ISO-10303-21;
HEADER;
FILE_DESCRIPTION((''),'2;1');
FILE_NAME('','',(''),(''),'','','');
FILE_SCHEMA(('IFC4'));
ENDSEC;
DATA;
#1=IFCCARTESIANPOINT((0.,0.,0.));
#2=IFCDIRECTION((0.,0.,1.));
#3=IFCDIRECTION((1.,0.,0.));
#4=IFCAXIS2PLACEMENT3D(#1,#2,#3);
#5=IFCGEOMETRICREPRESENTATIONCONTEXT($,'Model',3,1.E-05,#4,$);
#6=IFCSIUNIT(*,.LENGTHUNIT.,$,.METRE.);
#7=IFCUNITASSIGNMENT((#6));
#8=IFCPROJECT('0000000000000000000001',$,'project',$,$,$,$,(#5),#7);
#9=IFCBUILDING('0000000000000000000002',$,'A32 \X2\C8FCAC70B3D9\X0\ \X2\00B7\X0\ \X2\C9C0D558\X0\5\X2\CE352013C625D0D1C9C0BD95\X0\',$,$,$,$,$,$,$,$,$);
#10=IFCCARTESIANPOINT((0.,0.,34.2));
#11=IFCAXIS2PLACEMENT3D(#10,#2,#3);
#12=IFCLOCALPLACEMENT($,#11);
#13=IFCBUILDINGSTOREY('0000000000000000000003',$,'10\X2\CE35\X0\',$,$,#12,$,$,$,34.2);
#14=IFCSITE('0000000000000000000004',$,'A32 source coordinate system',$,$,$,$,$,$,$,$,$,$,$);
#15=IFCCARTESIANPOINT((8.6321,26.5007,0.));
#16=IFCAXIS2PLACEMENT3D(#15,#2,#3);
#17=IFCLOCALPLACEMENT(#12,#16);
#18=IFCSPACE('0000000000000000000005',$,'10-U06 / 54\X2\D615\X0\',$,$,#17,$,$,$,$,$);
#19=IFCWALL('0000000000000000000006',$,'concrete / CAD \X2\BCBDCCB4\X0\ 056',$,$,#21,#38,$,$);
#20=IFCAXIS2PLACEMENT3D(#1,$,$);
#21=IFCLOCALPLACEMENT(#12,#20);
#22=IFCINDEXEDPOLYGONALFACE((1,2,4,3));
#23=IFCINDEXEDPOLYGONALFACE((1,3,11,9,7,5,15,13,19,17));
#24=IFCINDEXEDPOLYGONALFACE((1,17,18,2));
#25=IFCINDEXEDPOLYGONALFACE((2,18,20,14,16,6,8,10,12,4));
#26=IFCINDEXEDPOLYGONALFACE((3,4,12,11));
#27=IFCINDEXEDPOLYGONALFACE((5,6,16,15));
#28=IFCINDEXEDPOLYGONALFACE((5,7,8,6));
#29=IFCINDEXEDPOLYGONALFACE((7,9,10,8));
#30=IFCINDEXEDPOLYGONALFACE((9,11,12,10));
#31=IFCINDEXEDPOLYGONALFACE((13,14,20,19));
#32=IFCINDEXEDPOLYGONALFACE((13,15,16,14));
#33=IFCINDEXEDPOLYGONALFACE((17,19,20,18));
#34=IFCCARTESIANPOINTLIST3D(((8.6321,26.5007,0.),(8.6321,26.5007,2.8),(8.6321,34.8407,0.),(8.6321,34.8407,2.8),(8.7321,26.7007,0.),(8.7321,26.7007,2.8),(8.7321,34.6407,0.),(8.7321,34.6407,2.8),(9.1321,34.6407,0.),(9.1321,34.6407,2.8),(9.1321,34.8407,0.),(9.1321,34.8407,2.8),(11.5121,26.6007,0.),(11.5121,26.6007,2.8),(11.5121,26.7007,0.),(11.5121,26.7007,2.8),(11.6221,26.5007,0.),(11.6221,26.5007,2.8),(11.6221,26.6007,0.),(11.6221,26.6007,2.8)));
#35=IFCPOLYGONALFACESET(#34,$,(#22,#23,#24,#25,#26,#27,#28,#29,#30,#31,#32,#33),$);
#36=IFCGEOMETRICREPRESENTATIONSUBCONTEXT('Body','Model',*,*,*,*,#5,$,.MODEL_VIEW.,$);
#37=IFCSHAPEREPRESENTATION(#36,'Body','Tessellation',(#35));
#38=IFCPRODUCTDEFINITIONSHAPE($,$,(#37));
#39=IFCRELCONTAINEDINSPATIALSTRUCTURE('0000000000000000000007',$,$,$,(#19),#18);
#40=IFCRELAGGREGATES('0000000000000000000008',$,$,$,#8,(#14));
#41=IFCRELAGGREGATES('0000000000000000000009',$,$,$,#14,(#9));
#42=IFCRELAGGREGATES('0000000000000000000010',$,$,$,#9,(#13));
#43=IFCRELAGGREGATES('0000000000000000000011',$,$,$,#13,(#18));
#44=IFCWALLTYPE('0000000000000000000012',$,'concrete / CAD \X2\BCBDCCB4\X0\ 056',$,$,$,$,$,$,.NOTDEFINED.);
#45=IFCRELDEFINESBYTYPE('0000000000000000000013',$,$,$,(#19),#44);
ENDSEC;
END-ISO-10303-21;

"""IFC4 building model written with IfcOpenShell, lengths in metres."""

from ifc_helpers import new_model, si_unit, frame, origin, origin_with_axes, place, context, subcontext, project, spatial, polyline, outline, extrude, source, transform, mapped, type_object, type_shapes, element, save


model = new_model("IFC4")

# Units and contexts
model_context = context("Model", 3, precision=1e-05, world=origin_with_axes())
body_context = subcontext(model_context, "Body", "Model", "MODEL_VIEW")
ifc_project = project(units=[si_unit("LENGTHUNIT", "METRE")], contexts=[model_context])

# Site, building, storey, space
site = spatial("IfcSite", under=ifc_project, Name="A32 source coordinate system")
building = spatial("IfcBuilding", under=site, Name="A32 주거동 · 지하5층–옥탑지붕")
storey_placement = place(None, frame((0.0, 0.0, 34.2), z_axis=(0.0, 0.0, 1.0), x_axis=(1.0, 0.0, 0.0)))
storey = spatial("IfcBuildingStorey", under=building, at=storey_placement, Name="10층", Elevation=34.2)
space_placement = place(storey_placement, frame((8.6321, 26.5007, 0.0), z_axis=(0.0, 0.0, 1.0), x_axis=(1.0, 0.0, 0.0)))
space = spatial("IfcSpace", under=storey, at=space_placement, Name="10-U06 / 54형")

# Wall
wall_type_1 = type_object("IfcWallType", Name="concrete / CAD 벽체 056", PredefinedType="NOTDEFINED")
shared_shape_1 = source(origin(), body_context, "Body", "SweptSolid", [
    extrude(outline(polyline([(0.1, 8.14), (0.1, 0.2), (2.88, 0.2), (2.88, 0.1), (2.99, 0.1), (2.99, 0.0), (0.0, 0.0), (0.0, 8.34), (-0.35, 8.34), (-0.35, 8.34), (0.5, 8.34), (0.5, 8.14), (0.1, 8.14)])), origin(), (0.0, 0.0, 1.0), 2.8),
])
type_shapes(wall_type_1, [shared_shape_1])
wall_1_placement = place(space_placement, origin_with_axes())
element("IfcWall", 1, at=wall_1_placement, inside=space, type_object=wall_type_1, Name="concrete / CAD 벽체 056", context=body_context, shape_type="MappedRepresentation", body=[
    mapped(shared_shape_1, transform((0.0, 0.0, 0.0), scale=1.0)),
])

save(model, "model.ifc")
